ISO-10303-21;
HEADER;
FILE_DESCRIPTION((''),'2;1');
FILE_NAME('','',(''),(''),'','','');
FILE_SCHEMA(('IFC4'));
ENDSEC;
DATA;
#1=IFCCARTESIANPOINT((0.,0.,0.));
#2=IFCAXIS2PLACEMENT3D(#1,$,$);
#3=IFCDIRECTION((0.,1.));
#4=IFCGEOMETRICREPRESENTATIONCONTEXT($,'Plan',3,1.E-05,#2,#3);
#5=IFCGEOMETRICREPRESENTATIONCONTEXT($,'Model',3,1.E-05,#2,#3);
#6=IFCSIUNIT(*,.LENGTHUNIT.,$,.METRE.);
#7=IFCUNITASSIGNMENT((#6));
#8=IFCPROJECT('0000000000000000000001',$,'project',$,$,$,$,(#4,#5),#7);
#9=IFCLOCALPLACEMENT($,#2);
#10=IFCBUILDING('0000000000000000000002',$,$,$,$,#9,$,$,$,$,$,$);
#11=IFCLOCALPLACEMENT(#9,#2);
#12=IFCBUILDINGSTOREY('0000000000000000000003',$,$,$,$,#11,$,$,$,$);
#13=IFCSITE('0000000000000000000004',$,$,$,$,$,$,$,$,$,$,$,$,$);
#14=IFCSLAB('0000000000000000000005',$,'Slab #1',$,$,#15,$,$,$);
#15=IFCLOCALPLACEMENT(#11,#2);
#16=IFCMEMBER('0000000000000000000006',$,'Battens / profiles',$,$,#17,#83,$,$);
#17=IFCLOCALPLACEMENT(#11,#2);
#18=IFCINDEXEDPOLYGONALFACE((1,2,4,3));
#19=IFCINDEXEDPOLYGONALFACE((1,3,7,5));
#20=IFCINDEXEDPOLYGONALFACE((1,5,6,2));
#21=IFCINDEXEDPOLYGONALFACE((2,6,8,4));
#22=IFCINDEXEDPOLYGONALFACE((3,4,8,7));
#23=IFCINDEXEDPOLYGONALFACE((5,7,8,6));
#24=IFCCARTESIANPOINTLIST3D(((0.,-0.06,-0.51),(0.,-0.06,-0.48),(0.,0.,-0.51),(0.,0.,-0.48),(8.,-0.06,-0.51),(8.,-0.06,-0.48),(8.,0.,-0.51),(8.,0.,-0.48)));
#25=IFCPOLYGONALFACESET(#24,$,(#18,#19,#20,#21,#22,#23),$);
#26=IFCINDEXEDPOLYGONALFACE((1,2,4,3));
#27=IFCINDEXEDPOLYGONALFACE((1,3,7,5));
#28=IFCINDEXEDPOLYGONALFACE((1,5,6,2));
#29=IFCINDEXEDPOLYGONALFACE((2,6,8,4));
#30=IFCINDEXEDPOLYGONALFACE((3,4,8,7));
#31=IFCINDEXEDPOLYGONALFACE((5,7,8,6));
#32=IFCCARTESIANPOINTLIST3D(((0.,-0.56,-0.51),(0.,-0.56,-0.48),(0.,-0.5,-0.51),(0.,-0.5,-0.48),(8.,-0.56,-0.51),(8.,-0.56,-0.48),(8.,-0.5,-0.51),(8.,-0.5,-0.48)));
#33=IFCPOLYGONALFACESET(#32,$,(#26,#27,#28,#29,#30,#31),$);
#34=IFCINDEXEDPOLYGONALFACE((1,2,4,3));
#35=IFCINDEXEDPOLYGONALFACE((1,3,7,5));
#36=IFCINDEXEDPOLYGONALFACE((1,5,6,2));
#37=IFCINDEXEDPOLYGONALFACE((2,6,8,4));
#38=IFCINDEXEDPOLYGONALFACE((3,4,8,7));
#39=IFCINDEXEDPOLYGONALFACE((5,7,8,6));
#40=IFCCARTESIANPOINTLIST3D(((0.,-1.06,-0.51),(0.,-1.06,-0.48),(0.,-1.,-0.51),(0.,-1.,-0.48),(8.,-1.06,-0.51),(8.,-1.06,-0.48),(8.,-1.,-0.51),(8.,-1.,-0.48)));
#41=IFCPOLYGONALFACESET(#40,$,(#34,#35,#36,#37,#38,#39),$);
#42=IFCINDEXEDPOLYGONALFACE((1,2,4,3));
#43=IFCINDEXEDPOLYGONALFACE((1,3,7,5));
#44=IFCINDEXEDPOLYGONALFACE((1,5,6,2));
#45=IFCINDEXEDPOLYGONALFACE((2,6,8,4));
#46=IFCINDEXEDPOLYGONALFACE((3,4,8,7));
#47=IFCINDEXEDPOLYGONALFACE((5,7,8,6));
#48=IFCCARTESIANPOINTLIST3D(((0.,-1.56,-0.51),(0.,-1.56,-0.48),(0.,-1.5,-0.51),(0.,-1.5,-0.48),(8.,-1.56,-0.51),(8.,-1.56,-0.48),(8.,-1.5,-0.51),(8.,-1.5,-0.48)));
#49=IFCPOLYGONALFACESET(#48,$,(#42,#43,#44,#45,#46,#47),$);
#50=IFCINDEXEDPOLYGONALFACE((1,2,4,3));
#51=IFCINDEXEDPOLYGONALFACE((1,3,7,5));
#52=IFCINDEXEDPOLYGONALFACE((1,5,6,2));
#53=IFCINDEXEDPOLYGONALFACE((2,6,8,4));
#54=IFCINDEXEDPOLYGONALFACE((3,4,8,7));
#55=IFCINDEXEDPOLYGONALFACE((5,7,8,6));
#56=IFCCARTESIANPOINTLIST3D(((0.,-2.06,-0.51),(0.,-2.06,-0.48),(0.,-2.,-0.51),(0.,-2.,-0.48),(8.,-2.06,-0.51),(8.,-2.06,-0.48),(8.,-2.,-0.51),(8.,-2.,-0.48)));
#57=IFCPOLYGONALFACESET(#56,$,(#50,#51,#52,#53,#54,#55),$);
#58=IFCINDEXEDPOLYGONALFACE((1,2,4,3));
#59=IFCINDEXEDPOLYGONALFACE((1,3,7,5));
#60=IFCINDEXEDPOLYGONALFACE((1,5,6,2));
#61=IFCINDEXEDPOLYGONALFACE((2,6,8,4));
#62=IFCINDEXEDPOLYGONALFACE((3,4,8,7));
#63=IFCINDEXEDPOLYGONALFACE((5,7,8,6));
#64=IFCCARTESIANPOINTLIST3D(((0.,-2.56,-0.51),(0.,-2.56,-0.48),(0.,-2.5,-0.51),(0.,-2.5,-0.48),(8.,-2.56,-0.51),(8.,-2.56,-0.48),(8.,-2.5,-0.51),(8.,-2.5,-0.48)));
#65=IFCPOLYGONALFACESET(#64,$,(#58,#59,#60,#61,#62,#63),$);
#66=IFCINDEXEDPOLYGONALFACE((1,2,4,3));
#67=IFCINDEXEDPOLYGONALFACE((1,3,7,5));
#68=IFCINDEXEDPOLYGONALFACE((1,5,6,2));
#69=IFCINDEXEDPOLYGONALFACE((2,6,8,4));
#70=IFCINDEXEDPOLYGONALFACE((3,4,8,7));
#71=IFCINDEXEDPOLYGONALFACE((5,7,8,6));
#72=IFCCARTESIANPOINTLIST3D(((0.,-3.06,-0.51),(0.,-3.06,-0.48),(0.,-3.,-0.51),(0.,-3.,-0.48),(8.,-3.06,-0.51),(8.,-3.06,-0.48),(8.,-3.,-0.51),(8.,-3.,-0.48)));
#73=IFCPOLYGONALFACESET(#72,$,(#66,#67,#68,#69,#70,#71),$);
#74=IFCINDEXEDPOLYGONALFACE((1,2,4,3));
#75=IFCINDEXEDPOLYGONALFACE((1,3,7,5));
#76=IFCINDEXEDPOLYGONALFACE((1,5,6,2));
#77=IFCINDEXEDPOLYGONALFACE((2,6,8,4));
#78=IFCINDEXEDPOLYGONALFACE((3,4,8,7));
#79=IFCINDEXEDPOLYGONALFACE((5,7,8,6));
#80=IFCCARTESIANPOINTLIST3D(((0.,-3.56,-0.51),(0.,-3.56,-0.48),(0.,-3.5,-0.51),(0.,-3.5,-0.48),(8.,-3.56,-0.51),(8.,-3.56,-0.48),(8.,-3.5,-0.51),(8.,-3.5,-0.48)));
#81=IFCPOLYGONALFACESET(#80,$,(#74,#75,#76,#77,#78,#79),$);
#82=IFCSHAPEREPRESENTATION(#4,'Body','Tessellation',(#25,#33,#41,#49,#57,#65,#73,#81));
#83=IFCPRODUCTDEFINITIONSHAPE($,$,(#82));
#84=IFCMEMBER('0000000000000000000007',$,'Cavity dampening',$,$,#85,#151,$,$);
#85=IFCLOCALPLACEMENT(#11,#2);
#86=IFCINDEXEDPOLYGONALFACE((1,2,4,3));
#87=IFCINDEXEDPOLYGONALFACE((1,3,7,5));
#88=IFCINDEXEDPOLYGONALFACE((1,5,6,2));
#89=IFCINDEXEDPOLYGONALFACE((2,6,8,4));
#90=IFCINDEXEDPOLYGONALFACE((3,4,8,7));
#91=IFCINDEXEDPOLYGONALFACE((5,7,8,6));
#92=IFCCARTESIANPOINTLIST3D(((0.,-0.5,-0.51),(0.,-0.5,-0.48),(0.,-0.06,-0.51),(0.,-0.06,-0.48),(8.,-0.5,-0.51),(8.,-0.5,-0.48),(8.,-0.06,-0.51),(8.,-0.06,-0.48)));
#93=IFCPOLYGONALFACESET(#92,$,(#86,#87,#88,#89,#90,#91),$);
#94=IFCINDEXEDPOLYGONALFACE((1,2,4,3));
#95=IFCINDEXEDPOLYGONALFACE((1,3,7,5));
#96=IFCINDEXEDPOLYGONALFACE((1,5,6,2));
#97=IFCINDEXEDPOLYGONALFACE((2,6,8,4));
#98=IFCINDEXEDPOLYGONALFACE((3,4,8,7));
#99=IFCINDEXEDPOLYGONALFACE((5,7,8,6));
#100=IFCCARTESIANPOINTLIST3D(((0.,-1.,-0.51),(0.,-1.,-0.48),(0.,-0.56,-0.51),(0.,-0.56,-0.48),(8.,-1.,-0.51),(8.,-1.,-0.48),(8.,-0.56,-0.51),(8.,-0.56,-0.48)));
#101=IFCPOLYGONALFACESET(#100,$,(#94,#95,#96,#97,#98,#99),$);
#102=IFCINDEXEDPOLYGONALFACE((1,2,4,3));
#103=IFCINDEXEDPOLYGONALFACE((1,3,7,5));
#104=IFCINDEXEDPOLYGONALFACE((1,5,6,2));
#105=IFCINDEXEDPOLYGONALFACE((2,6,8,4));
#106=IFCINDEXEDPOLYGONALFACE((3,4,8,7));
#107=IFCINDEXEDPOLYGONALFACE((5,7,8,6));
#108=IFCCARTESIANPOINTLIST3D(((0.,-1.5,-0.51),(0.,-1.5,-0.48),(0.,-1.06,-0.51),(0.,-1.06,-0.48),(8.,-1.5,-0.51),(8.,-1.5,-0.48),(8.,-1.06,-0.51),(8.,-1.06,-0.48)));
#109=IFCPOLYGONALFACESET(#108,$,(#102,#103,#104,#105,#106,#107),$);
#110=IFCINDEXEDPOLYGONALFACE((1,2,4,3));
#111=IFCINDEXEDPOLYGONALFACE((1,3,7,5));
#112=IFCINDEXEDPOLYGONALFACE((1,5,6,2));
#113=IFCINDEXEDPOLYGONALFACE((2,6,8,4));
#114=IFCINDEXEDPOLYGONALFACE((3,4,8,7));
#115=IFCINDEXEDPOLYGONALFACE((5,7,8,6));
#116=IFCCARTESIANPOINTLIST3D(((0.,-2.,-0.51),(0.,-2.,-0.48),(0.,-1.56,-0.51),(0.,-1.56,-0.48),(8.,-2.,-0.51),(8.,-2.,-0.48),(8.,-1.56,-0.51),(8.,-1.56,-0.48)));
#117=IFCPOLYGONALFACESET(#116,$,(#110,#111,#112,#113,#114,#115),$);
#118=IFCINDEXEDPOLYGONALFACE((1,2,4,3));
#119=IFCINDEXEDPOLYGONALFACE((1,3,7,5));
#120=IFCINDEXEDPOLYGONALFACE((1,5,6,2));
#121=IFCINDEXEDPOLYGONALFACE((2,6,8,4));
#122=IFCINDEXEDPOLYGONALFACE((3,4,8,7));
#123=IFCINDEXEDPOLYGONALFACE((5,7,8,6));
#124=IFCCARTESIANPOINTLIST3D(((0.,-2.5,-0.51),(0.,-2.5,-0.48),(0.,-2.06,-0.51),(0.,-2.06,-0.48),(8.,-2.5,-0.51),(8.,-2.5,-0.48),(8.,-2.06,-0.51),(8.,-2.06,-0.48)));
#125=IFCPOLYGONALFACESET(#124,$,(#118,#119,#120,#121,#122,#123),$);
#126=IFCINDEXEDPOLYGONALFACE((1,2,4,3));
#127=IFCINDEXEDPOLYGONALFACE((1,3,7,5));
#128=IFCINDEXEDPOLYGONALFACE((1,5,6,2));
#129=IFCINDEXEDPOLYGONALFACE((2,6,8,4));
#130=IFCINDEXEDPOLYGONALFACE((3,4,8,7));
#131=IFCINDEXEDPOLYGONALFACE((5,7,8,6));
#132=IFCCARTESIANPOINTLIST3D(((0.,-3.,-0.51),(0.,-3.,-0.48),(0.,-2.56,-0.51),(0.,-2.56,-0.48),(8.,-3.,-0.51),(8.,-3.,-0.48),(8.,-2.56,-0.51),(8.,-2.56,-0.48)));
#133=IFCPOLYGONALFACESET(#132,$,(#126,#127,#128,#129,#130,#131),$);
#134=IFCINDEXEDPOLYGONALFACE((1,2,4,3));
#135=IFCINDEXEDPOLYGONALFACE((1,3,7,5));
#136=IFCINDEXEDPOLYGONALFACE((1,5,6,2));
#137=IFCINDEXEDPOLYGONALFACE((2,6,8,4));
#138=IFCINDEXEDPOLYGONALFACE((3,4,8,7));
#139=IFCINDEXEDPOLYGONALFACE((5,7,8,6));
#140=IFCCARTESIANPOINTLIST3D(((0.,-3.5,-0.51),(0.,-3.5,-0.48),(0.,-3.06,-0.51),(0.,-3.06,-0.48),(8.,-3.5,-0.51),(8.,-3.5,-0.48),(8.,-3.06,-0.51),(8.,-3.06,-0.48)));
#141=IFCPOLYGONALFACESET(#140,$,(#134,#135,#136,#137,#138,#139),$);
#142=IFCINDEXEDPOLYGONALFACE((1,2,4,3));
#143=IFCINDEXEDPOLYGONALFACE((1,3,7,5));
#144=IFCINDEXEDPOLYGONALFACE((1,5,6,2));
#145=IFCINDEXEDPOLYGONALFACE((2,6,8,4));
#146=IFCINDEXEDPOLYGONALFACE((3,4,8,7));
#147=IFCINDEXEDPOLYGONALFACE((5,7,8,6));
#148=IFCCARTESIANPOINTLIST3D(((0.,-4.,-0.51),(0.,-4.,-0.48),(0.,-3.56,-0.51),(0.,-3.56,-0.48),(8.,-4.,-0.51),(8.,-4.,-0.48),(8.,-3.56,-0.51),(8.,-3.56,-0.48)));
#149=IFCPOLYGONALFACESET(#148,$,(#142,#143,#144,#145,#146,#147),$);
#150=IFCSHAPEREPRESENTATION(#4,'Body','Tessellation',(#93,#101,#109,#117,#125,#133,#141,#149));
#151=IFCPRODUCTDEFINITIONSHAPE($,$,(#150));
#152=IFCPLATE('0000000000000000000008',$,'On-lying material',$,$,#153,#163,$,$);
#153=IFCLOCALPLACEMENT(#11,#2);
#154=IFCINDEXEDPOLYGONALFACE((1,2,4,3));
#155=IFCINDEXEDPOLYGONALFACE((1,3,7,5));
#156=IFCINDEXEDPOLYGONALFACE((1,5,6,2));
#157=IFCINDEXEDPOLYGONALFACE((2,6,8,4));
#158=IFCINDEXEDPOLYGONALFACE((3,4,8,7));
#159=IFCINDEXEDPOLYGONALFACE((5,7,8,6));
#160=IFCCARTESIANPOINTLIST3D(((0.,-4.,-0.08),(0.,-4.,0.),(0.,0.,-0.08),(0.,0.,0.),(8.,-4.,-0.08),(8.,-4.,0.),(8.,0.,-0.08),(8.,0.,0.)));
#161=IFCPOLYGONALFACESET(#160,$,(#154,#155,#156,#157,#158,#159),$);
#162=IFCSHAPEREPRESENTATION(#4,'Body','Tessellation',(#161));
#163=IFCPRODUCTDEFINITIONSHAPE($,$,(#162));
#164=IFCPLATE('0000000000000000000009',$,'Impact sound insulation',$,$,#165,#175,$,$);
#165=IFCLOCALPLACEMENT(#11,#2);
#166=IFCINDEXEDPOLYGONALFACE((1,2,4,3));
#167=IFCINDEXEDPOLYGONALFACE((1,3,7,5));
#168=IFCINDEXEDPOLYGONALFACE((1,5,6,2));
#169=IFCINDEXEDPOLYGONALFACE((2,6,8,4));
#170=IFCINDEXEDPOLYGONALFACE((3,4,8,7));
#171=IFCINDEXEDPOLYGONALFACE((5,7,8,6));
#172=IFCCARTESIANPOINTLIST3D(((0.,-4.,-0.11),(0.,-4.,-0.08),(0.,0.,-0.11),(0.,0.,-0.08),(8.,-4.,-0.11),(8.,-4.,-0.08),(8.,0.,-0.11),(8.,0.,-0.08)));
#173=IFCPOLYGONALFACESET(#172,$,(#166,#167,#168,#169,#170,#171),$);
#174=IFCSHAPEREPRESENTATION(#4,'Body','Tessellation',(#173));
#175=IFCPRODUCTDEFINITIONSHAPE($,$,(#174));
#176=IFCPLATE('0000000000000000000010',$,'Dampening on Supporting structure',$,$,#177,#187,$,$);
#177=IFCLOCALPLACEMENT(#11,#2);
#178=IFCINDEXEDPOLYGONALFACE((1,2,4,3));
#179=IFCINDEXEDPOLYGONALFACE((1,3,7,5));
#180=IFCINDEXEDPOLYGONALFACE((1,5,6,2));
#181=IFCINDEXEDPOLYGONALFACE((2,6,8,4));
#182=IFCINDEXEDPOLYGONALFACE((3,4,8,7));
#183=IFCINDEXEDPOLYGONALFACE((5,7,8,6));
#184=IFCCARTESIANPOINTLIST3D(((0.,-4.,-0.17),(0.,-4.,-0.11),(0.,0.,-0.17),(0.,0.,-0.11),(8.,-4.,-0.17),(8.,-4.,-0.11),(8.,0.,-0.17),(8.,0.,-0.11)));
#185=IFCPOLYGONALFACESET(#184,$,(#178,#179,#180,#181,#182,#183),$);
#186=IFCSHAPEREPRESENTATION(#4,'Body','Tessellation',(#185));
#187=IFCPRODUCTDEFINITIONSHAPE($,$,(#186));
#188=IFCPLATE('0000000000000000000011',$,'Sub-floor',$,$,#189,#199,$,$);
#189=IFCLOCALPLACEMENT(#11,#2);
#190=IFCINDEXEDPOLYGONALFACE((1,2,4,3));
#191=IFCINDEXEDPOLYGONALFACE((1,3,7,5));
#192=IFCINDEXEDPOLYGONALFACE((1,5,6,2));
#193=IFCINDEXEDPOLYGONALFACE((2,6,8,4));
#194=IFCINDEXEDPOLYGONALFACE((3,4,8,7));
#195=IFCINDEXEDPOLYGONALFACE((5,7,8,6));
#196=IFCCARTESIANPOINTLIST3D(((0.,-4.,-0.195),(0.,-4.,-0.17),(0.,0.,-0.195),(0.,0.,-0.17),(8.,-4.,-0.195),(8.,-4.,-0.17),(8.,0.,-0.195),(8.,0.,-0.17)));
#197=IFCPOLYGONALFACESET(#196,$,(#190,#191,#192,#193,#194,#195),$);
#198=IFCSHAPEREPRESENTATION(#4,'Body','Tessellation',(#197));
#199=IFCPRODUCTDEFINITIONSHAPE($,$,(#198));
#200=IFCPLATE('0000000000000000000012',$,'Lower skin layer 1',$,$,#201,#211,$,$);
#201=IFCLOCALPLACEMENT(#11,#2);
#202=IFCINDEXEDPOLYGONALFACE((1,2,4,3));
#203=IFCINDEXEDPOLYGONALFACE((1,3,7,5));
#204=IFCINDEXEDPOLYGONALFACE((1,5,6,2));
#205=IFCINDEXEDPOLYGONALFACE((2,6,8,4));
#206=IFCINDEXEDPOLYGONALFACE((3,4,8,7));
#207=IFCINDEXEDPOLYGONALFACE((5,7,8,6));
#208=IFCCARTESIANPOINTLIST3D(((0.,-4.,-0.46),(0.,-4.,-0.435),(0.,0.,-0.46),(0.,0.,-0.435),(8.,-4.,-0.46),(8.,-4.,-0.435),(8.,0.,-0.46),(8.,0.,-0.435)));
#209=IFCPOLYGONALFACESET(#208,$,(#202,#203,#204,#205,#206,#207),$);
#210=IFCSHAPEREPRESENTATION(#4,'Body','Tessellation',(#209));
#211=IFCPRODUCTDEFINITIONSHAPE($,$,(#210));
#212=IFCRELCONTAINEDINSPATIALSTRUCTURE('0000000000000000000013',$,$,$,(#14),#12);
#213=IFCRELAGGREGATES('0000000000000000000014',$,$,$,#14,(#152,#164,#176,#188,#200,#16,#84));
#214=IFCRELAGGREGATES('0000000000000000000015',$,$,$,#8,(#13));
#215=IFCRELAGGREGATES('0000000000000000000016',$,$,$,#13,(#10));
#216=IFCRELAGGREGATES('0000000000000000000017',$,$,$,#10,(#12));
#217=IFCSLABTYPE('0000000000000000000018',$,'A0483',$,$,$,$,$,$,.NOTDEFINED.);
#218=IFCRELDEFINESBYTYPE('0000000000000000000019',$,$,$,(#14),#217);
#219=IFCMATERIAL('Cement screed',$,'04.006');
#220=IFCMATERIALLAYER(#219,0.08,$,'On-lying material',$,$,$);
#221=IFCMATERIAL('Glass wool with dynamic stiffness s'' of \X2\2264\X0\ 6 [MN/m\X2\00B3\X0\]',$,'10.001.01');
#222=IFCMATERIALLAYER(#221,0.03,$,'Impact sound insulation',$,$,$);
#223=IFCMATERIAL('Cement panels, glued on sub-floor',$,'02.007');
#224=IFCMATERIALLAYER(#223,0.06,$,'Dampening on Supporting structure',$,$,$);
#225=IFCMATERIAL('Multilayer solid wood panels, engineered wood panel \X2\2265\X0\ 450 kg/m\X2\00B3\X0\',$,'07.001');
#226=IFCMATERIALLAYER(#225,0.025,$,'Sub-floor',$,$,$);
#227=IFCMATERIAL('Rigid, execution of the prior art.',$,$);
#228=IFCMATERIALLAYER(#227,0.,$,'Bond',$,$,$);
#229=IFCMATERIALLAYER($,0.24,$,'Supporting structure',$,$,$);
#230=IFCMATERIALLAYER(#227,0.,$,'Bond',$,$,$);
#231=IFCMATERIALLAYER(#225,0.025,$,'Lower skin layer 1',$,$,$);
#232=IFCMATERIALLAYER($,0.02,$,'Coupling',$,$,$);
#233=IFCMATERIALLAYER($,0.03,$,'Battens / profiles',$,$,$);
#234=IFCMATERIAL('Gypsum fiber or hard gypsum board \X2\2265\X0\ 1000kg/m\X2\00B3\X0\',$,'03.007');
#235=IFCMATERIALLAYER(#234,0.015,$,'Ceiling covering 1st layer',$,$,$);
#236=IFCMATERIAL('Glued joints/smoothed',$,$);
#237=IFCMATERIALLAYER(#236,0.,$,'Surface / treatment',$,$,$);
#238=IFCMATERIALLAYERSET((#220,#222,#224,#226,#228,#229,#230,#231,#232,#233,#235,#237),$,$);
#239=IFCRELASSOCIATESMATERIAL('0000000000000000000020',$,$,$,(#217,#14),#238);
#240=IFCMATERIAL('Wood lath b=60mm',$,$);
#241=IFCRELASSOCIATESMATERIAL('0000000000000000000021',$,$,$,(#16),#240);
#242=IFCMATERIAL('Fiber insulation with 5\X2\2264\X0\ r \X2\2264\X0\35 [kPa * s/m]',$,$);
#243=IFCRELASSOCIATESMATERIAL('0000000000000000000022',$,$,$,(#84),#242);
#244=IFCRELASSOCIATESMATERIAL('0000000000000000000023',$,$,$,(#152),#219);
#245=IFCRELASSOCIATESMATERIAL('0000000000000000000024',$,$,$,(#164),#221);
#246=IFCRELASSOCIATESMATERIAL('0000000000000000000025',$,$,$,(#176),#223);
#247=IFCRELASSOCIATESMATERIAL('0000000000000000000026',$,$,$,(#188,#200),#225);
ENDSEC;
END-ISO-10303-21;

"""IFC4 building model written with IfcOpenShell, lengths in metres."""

from ifc_helpers import new_model, si_unit, direction, frame, frame_2d, origin, origin_with_axes, place, context, project, spatial, rectangle, extrude, material, layer, layer_set, type_object, element, aggregate, save


model = new_model("IFC4")

# Units and contexts
plan_context = context("Plan", 3, precision=1e-05, world=origin(), true_north=direction((0.0, 1.0)))
model_context = context("Model", 3, precision=1e-05, world=origin(), true_north=direction((0.0, 1.0)))
ifc_project = project(units=[si_unit("LENGTHUNIT", "METRE")], contexts=[plan_context, model_context])

# Site, building, storey
site = spatial("IfcSite", under=ifc_project)
building_placement = place(None, origin())
building = spatial("IfcBuilding", under=site, at=building_placement)
storey_placement = place(building_placement, origin())
storey = spatial("IfcBuildingStorey", under=building, at=storey_placement)

# Slab, members, plates
ifc_material_1 = material(Name="Cement screed", Category="04.006")
ifc_layer_1 = layer(ifc_material_1, 0.08, Name="On-lying material")
ifc_material_2 = material(Name="Glass wool with dynamic stiffness s' of ≤ 6 [MN/m³]", Category="10.001.01")
ifc_layer_2 = layer(ifc_material_2, 0.03, Name="Impact sound insulation")
ifc_material_3 = material(Name="Cement panels, glued on sub-floor", Category="02.007")
ifc_layer_3 = layer(ifc_material_3, 0.06, Name="Dampening on Supporting structure")
ifc_material_4 = material(Name="Multilayer solid wood panels, engineered wood panel ≥ 450 kg/m³", Category="07.001")
ifc_layer_4 = layer(ifc_material_4, 0.025, Name="Sub-floor")
ifc_material_5 = material(Name="Rigid, execution of the prior art.")
ifc_layer_5 = layer(ifc_material_5, 0.0, Name="Bond")
ifc_layer_6 = layer(None, 0.24, Name="Supporting structure")
ifc_layer_7 = layer(ifc_material_5, 0.0, Name="Bond")
ifc_layer_8 = layer(ifc_material_4, 0.025, Name="Lower skin layer 1")
ifc_layer_9 = layer(None, 0.02, Name="Coupling")
ifc_layer_10 = layer(None, 0.03, Name="Battens / profiles")
ifc_material_6 = material(Name="Gypsum fiber or hard gypsum board ≥ 1000kg/m³", Category="03.007")
ifc_layer_11 = layer(ifc_material_6, 0.015, Name="Ceiling covering 1st layer")
ifc_material_7 = material(Name="Glued joints/smoothed")
ifc_layer_12 = layer(ifc_material_7, 0.0, Name="Surface / treatment")
ifc_layer_set = layer_set([ifc_layer_1, ifc_layer_2, ifc_layer_3, ifc_layer_4, ifc_layer_5, ifc_layer_6, ifc_layer_7, ifc_layer_8, ifc_layer_9, ifc_layer_10, ifc_layer_11, ifc_layer_12])
slab_type = type_object("IfcSlabType", Name="A0483", PredefinedType="NOTDEFINED", material=ifc_layer_set)
slab_placement = place(None, frame((0.0, 0.0, 0.0), z_axis=(0.0, 0.0, -1.0), x_axis=(1.0, 0.0, 0.0)))
slab = element("IfcSlab", 1, at=slab_placement, inside=storey, type_object=slab_type, material=ifc_layer_set, Name="Slab #1")
ifc_material_8 = material(Name="Fiber insulation with 5≤ r ≤35 [kPa * s/m]")
ifc_material_9 = material(Name="Wood lath b=60mm")
member_1_placement = place(slab_placement, origin())
member_1 = element("IfcMember", 2, at=member_1_placement, material=ifc_material_9, Name="Battens / profiles", context=plan_context, shape_type="SweptSolid", body=[
    extrude(rectangle(XDim=0.06, YDim=0.03, at=frame_2d((0.03, 0.015), x_axis=(1.0, 0.0))), frame((0.0, 0.0, 0.48), z_axis=(1.0, 0.0, 0.0), x_axis=(0.0, 1.0, 0.0)), (0.0, 0.0, 1.0), 8.0),
    extrude(rectangle(XDim=0.06, YDim=0.03, at=frame_2d((0.03, 0.015), x_axis=(1.0, 0.0))), frame((0.0, 0.5, 0.48), z_axis=(1.0, 0.0, 0.0), x_axis=(0.0, 1.0, 0.0)), (0.0, 0.0, 1.0), 8.0),
    extrude(rectangle(XDim=0.06, YDim=0.03, at=frame_2d((0.03, 0.015), x_axis=(1.0, 0.0))), frame((0.0, 1.0, 0.48), z_axis=(1.0, 0.0, 0.0), x_axis=(0.0, 1.0, 0.0)), (0.0, 0.0, 1.0), 8.0),
    extrude(rectangle(XDim=0.06, YDim=0.03, at=frame_2d((0.03, 0.015), x_axis=(1.0, 0.0))), frame((0.0, 1.5, 0.48), z_axis=(1.0, 0.0, 0.0), x_axis=(0.0, 1.0, 0.0)), (0.0, 0.0, 1.0), 8.0),
    extrude(rectangle(XDim=0.06, YDim=0.03, at=frame_2d((0.03, 0.015), x_axis=(1.0, 0.0))), frame((0.0, 2.0, 0.48), z_axis=(1.0, 0.0, 0.0), x_axis=(0.0, 1.0, 0.0)), (0.0, 0.0, 1.0), 8.0),
    extrude(rectangle(XDim=0.06, YDim=0.03, at=frame_2d((0.03, 0.015), x_axis=(1.0, 0.0))), frame((0.0, 2.5, 0.48), z_axis=(1.0, 0.0, 0.0), x_axis=(0.0, 1.0, 0.0)), (0.0, 0.0, 1.0), 8.0),
    extrude(rectangle(XDim=0.06, YDim=0.03, at=frame_2d((0.03, 0.015), x_axis=(1.0, 0.0))), frame((0.0, 3.0, 0.48), z_axis=(1.0, 0.0, 0.0), x_axis=(0.0, 1.0, 0.0)), (0.0, 0.0, 1.0), 8.0),
    extrude(rectangle(XDim=0.06, YDim=0.03, at=frame_2d((0.03, 0.015), x_axis=(1.0, 0.0))), frame((0.0, 3.5, 0.48), z_axis=(1.0, 0.0, 0.0), x_axis=(0.0, 1.0, 0.0)), (0.0, 0.0, 1.0), 8.0),
])
member_2_placement = place(slab_placement, origin())
member_2 = element("IfcMember", 3, at=member_2_placement, material=ifc_material_8, Name="Cavity dampening", context=plan_context, shape_type="SweptSolid", body=[
    extrude(rectangle(XDim=0.44, YDim=0.03, at=frame_2d((0.22, 0.015), x_axis=(1.0, 0.0))), frame((0.0, 0.06, 0.48), z_axis=(1.0, 0.0, 0.0), x_axis=(0.0, 1.0, 0.0)), (0.0, 0.0, 1.0), 8.0),
    extrude(rectangle(XDim=0.44, YDim=0.03, at=frame_2d((0.22, 0.015), x_axis=(1.0, 0.0))), frame((0.0, 0.56, 0.48), z_axis=(1.0, 0.0, 0.0), x_axis=(0.0, 1.0, 0.0)), (0.0, 0.0, 1.0), 8.0),
    extrude(rectangle(XDim=0.44, YDim=0.03, at=frame_2d((0.22, 0.015), x_axis=(1.0, 0.0))), frame((0.0, 1.06, 0.48), z_axis=(1.0, 0.0, 0.0), x_axis=(0.0, 1.0, 0.0)), (0.0, 0.0, 1.0), 8.0),
    extrude(rectangle(XDim=0.44, YDim=0.03, at=frame_2d((0.22, 0.015), x_axis=(1.0, 0.0))), frame((0.0, 1.56, 0.48), z_axis=(1.0, 0.0, 0.0), x_axis=(0.0, 1.0, 0.0)), (0.0, 0.0, 1.0), 8.0),
    extrude(rectangle(XDim=0.44, YDim=0.03, at=frame_2d((0.22, 0.015), x_axis=(1.0, 0.0))), frame((0.0, 2.06, 0.48), z_axis=(1.0, 0.0, 0.0), x_axis=(0.0, 1.0, 0.0)), (0.0, 0.0, 1.0), 8.0),
    extrude(rectangle(XDim=0.44, YDim=0.03, at=frame_2d((0.22, 0.015), x_axis=(1.0, 0.0))), frame((0.0, 2.56, 0.48), z_axis=(1.0, 0.0, 0.0), x_axis=(0.0, 1.0, 0.0)), (0.0, 0.0, 1.0), 8.0),
    extrude(rectangle(XDim=0.44, YDim=0.03, at=frame_2d((0.22, 0.015), x_axis=(1.0, 0.0))), frame((0.0, 3.06, 0.48), z_axis=(1.0, 0.0, 0.0), x_axis=(0.0, 1.0, 0.0)), (0.0, 0.0, 1.0), 8.0),
    extrude(rectangle(XDim=0.44, YDim=0.03, at=frame_2d((0.22, 0.015), x_axis=(1.0, 0.0))), frame((0.0, 3.56, 0.48), z_axis=(1.0, 0.0, 0.0), x_axis=(0.0, 1.0, 0.0)), (0.0, 0.0, 1.0), 8.0),
])
plate_1_placement = place(slab_placement, origin())
plate_1 = element("IfcPlate", 4, at=plate_1_placement, material=ifc_material_1, Name="On-lying material", context=plan_context, shape_type="SweptSolid", body=[
    extrude(rectangle(XDim=8.0, YDim=4.0, at=frame_2d((4.0, 2.0), x_axis=(1.0, 0.0))), origin_with_axes(), (0.0, 0.0, 1.0), 0.08),
])
plate_2_placement = place(slab_placement, origin())
plate_2 = element("IfcPlate", 5, at=plate_2_placement, material=ifc_material_2, Name="Impact sound insulation", context=plan_context, shape_type="SweptSolid", body=[
    extrude(rectangle(XDim=8.0, YDim=4.0, at=frame_2d((4.0, 2.0), x_axis=(1.0, 0.0))), frame((0.0, 0.0, 0.08), z_axis=(0.0, 0.0, 1.0), x_axis=(1.0, 0.0, 0.0)), (0.0, 0.0, 1.0), 0.03),
])
plate_3_placement = place(slab_placement, origin())
plate_3 = element("IfcPlate", 6, at=plate_3_placement, material=ifc_material_3, Name="Dampening on Supporting structure", context=plan_context, shape_type="SweptSolid", body=[
    extrude(rectangle(XDim=8.0, YDim=4.0, at=frame_2d((4.0, 2.0), x_axis=(1.0, 0.0))), frame((0.0, 0.0, 0.11), z_axis=(0.0, 0.0, 1.0), x_axis=(1.0, 0.0, 0.0)), (0.0, 0.0, 1.0), 0.06),
])
plate_4_placement = place(slab_placement, origin())
plate_4 = element("IfcPlate", 7, at=plate_4_placement, material=ifc_material_4, Name="Sub-floor", context=plan_context, shape_type="SweptSolid", body=[
    extrude(rectangle(XDim=8.0, YDim=4.0, at=frame_2d((4.0, 2.0), x_axis=(1.0, 0.0))), frame((0.0, 0.0, 0.17), z_axis=(0.0, 0.0, 1.0), x_axis=(1.0, 0.0, 0.0)), (0.0, 0.0, 1.0), 0.025),
])
plate_5_placement = place(slab_placement, origin())
plate_5 = element("IfcPlate", 8, at=plate_5_placement, material=ifc_material_4, Name="Lower skin layer 1", context=plan_context, shape_type="SweptSolid", body=[
    extrude(rectangle(XDim=8.0, YDim=4.0, at=frame_2d((4.0, 2.0), x_axis=(1.0, 0.0))), frame((0.0, 0.0, 0.435), z_axis=(0.0, 0.0, 1.0), x_axis=(1.0, 0.0, 0.0)), (0.0, 0.0, 1.0), 0.025),
])
aggregate(slab, [plate_1, plate_2, plate_3, plate_4, plate_5, member_1, member_2])

save(model, "model.ifc")
